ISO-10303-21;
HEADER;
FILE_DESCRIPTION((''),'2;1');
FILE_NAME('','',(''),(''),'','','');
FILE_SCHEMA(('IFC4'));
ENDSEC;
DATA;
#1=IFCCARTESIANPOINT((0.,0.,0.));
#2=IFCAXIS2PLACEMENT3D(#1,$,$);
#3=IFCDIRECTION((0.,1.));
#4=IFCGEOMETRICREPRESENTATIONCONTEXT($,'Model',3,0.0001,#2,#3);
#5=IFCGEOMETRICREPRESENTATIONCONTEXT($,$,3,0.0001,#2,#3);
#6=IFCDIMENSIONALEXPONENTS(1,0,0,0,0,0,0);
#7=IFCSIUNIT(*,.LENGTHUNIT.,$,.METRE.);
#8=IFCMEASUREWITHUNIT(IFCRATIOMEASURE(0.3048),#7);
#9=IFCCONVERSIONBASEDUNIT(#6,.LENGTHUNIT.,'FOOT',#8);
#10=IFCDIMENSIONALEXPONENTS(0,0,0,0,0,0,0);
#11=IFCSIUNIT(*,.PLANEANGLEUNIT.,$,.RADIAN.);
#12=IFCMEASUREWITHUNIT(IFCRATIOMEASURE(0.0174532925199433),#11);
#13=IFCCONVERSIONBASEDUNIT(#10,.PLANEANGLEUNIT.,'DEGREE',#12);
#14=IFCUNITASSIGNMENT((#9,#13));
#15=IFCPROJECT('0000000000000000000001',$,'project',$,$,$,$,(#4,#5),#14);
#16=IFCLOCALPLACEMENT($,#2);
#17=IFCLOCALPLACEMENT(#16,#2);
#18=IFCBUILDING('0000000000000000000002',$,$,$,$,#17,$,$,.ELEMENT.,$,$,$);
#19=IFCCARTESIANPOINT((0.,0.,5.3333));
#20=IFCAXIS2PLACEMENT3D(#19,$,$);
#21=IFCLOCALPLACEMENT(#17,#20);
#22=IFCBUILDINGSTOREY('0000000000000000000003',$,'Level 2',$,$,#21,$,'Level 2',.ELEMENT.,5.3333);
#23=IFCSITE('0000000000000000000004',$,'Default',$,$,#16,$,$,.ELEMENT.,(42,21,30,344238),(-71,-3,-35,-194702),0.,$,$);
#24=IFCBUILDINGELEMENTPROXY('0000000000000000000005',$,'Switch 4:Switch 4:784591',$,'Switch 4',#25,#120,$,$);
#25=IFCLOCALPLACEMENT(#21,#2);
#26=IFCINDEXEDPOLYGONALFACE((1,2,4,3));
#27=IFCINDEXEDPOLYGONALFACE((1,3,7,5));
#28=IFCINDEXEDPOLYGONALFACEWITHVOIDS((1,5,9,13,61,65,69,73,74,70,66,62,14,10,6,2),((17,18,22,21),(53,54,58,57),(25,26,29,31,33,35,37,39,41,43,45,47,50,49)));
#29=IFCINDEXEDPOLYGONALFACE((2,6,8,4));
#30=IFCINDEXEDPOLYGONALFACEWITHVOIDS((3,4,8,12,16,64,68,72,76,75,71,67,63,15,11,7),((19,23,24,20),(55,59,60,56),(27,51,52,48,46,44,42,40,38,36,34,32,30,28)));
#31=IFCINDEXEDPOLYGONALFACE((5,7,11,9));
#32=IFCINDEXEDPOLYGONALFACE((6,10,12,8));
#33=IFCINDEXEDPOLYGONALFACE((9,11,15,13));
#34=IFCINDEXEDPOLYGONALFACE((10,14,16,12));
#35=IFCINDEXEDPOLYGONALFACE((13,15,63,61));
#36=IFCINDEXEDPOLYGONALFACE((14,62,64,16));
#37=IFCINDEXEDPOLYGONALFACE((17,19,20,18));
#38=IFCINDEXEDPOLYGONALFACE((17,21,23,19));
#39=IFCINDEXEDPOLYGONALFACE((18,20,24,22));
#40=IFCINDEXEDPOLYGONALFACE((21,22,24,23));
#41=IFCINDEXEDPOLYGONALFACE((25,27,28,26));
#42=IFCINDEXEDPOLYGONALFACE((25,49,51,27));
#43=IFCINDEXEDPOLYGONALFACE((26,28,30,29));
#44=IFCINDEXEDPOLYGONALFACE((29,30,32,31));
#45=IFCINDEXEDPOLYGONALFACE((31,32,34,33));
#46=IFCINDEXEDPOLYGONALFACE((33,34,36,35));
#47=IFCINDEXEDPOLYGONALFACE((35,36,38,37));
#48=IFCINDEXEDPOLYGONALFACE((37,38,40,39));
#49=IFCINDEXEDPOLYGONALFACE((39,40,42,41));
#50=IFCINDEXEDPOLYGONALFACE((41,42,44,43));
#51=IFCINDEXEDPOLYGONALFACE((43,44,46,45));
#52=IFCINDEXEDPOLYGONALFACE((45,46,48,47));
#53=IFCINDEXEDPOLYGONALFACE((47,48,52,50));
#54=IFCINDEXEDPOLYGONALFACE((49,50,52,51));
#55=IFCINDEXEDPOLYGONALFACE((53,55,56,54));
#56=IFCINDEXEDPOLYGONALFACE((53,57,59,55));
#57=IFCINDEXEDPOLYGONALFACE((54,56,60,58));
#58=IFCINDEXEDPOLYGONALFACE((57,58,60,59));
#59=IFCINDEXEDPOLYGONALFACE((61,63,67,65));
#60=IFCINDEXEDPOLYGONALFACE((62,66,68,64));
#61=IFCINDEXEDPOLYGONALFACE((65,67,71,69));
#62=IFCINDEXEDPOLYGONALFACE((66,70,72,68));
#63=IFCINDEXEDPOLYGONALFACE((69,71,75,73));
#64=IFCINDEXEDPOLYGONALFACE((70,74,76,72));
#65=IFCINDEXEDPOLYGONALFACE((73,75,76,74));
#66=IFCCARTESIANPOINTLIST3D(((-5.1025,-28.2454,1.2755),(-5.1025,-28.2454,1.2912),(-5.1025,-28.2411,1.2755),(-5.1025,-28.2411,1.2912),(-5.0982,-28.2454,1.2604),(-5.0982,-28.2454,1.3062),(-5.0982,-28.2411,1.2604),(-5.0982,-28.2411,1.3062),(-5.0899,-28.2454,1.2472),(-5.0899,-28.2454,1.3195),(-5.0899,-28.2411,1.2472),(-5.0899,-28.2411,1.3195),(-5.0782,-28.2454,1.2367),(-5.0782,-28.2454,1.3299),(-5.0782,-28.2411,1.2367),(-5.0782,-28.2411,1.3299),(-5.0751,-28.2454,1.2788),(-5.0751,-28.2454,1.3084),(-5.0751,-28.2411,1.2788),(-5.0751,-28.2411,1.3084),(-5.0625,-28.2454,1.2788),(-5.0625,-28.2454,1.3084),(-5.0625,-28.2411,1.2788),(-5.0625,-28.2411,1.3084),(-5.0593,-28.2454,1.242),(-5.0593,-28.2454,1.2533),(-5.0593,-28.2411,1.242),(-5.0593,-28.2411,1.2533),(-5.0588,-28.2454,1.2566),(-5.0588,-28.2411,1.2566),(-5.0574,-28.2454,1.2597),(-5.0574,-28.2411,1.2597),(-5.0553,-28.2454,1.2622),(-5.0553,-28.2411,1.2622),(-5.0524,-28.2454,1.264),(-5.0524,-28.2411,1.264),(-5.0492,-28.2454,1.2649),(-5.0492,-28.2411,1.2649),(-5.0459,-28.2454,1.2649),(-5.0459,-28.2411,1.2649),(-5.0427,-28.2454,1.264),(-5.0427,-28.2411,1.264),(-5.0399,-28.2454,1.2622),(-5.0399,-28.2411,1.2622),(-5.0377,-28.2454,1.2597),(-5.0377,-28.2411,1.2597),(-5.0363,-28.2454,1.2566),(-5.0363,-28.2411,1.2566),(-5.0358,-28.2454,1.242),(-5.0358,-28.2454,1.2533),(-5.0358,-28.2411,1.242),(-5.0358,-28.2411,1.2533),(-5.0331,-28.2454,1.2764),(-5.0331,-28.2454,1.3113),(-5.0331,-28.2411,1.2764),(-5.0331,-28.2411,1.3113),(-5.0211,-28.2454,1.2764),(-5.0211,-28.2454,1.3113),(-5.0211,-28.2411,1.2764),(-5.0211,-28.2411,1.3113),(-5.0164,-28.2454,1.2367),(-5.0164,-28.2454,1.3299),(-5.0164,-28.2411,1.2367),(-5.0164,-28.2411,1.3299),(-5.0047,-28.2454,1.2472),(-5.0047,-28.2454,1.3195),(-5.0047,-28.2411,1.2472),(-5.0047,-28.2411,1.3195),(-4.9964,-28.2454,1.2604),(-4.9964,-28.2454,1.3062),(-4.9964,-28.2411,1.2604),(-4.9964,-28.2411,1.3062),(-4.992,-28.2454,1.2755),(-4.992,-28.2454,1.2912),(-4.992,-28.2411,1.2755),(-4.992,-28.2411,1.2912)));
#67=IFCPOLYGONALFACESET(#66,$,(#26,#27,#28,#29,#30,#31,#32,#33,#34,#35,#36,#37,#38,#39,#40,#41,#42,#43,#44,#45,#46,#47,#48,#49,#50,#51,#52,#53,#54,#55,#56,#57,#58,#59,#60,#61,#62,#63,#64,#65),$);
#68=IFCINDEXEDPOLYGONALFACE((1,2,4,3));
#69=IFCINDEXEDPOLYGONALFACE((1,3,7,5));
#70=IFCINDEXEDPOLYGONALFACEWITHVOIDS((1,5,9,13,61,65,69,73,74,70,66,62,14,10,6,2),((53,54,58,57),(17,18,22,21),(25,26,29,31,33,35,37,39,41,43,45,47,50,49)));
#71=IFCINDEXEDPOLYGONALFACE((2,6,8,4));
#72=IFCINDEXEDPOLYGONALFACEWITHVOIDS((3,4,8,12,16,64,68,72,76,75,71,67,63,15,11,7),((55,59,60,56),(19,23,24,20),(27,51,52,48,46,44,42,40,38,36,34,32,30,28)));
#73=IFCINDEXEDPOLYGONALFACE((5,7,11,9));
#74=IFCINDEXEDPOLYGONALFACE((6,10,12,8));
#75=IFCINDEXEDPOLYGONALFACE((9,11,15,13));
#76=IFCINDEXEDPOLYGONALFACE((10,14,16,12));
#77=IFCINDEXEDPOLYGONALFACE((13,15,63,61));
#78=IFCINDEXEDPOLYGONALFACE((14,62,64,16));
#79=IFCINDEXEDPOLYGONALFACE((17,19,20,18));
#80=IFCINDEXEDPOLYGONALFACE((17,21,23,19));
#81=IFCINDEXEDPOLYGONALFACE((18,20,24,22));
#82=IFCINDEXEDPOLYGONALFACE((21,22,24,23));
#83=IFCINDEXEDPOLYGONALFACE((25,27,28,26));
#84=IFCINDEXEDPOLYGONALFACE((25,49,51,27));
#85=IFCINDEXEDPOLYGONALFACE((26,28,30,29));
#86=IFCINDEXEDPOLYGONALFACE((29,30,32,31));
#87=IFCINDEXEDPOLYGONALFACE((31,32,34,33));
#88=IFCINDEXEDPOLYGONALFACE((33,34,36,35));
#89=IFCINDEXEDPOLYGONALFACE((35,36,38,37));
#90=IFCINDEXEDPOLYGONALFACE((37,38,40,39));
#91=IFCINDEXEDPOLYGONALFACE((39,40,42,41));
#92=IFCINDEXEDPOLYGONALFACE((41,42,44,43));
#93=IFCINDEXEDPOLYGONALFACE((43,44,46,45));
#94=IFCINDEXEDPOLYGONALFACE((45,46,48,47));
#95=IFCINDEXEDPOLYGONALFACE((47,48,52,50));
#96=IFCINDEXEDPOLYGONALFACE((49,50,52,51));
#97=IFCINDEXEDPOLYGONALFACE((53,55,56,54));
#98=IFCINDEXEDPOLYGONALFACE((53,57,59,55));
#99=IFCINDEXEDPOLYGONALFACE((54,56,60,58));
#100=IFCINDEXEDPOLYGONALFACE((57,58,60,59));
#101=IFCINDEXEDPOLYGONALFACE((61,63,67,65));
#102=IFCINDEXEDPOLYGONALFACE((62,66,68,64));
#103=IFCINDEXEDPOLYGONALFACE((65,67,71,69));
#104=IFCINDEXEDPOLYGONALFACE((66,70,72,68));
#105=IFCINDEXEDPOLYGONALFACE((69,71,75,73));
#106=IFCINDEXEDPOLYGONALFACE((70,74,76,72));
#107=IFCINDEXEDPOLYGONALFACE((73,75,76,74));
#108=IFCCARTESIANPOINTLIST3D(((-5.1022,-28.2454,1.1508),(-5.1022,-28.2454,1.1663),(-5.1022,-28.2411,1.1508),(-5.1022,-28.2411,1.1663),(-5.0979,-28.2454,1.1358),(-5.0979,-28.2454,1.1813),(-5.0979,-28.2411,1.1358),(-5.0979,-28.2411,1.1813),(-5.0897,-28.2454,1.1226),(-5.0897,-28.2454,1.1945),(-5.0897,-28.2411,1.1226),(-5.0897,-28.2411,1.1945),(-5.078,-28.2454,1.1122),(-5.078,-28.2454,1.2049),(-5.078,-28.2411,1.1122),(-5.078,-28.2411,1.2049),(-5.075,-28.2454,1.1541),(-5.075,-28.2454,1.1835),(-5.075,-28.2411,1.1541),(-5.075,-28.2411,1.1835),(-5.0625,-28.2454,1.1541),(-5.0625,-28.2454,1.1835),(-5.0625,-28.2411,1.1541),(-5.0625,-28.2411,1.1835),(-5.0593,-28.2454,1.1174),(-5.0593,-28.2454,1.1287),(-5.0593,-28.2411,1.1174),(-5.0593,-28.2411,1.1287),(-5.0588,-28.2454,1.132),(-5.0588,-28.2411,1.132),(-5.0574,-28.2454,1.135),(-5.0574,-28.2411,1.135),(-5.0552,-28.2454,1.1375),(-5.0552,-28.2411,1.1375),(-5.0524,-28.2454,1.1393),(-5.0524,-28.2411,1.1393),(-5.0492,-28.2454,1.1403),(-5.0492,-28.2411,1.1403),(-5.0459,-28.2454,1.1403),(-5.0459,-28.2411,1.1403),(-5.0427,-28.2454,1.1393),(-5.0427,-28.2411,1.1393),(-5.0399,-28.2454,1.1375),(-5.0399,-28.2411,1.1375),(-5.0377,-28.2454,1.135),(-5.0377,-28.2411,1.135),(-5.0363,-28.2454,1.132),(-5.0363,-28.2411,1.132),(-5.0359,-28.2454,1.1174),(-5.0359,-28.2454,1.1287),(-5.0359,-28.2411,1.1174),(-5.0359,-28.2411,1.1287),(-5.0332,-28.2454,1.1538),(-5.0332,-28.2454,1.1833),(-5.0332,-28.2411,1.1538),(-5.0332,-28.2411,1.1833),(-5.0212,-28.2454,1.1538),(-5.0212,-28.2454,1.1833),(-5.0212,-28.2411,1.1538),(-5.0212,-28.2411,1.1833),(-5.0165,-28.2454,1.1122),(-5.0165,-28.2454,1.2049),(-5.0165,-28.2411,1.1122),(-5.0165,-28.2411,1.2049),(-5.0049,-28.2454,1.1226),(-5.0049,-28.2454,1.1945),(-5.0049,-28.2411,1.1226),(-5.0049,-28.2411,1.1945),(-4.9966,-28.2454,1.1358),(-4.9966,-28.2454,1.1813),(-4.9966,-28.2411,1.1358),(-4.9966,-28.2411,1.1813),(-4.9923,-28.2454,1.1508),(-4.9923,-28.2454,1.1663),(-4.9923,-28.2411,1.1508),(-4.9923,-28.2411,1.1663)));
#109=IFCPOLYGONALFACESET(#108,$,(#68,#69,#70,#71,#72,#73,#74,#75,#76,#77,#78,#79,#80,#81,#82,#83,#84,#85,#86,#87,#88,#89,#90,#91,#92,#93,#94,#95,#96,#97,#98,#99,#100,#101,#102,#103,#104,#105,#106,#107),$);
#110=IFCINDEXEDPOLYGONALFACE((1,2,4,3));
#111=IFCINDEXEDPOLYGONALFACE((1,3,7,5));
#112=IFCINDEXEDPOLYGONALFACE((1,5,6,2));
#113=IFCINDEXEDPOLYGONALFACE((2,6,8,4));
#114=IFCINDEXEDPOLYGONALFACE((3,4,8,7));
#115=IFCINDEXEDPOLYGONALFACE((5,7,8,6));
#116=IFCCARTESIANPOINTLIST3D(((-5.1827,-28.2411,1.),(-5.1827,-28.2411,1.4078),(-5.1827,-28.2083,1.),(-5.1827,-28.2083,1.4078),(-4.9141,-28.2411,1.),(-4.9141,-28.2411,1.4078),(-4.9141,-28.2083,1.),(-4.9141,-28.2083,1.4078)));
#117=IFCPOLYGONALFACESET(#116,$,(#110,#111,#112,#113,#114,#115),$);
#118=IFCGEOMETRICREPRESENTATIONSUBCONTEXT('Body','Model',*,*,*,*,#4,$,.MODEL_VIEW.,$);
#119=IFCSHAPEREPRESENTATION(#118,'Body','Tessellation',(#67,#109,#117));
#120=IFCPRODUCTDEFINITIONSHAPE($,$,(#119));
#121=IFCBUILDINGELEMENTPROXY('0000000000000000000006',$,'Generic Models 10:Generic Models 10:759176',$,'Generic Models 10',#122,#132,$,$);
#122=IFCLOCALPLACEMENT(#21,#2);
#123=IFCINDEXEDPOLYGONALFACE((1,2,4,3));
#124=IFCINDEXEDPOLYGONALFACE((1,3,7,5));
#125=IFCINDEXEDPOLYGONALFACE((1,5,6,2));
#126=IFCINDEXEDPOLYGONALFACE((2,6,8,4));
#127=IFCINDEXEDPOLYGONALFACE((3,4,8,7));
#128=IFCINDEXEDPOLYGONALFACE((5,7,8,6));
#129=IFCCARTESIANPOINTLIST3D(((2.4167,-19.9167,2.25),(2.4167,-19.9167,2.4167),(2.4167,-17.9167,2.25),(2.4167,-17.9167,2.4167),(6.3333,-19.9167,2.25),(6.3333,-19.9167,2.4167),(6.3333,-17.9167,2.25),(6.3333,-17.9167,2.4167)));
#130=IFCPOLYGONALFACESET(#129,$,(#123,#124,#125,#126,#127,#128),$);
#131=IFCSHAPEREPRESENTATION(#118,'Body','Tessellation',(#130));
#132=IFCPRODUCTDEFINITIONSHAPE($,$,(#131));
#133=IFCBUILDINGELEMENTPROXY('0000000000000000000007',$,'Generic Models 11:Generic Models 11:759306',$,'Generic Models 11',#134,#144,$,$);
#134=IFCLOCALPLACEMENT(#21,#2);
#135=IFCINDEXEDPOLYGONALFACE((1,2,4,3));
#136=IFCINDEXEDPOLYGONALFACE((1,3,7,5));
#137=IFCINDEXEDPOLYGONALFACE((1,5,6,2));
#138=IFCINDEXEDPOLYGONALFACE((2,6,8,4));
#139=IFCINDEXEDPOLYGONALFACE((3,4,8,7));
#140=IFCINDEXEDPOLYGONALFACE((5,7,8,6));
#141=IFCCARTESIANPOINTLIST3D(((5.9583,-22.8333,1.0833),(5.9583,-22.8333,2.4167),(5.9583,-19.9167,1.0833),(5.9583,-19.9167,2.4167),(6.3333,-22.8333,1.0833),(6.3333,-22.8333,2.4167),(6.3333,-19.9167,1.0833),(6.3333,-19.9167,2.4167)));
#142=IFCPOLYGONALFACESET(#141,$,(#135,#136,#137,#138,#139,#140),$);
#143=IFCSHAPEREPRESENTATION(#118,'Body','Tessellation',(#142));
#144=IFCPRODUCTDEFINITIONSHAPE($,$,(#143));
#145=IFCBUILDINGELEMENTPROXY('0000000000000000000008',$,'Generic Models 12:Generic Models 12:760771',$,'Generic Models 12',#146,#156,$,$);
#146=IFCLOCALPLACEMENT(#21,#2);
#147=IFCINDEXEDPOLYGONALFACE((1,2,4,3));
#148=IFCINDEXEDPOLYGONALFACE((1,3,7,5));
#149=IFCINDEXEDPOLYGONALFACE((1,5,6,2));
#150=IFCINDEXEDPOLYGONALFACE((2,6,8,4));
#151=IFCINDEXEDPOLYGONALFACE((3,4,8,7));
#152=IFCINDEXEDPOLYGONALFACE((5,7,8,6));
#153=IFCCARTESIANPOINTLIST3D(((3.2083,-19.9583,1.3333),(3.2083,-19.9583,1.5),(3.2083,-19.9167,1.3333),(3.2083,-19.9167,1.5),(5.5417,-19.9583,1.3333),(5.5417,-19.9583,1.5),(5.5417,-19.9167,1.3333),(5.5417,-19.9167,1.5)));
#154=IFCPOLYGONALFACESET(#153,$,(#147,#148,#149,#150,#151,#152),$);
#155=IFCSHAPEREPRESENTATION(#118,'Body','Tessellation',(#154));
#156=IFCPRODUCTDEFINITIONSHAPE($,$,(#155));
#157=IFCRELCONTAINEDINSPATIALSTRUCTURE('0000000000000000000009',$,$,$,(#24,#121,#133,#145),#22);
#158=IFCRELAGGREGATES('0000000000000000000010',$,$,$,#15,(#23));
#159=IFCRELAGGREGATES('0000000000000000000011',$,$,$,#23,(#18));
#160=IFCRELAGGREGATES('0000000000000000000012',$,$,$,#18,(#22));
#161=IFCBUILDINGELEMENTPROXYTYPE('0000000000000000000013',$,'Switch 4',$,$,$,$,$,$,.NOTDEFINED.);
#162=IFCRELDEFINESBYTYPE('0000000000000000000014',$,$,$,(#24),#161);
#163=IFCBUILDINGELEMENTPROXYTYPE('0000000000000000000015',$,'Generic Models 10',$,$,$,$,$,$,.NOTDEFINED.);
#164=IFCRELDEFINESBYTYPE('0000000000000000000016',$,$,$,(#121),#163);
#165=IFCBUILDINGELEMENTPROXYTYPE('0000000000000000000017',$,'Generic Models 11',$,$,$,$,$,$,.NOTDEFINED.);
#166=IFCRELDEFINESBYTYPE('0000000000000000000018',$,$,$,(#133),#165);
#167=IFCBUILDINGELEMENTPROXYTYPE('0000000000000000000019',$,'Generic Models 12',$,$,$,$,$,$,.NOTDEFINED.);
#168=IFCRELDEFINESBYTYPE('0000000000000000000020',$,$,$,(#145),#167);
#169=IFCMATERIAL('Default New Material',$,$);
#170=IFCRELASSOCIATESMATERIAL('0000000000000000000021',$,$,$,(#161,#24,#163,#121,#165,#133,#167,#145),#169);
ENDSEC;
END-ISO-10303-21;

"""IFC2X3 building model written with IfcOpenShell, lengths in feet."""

from ifc_helpers import new_model, entity, si_unit, converted_unit, direction, frame, frame_2d, origin, origin_2d_with_axis, place, context, subcontext, project, spatial, polyline, circle_curve, parameter, trimmed, segment, composite_curve, rectangle, outline, extrude, source, transform, mapped, material, type_object, type_shapes, element, save


model = new_model("IFC2X3")

# Units and contexts
model_context = context("Model", 3, precision=0.0001, world=origin(), true_north=direction((0.0, 1.0)))
context_of_model = context(None, 3, precision=0.0001, world=origin(), true_north=direction((0.0, 1.0)))
body_context = subcontext(model_context, "Body", "Model", "MODEL_VIEW")
ifc_project = project(units=[converted_unit("LENGTHUNIT", "FOOT", entity("IfcRatioMeasure", 0.3048), si_unit("LENGTHUNIT", "METRE"), dimensions=[1, 0, 0, 0, 0, 0, 0]), converted_unit("PLANEANGLEUNIT", "DEGREE", entity("IfcRatioMeasure", 0.0174532925199433), si_unit("PLANEANGLEUNIT", "RADIAN"), dimensions=[0, 0, 0, 0, 0, 0, 0])], contexts=[model_context, context_of_model])

# Site, building, storey
site_placement = place(None, origin())
site = spatial("IfcSite", under=ifc_project, at=site_placement, Name="Default", CompositionType="ELEMENT", RefLatitude=(42, 21, 30, 344238), RefLongitude=(-71, -3, -35, -194702), RefElevation=0.0)
building_placement = place(site_placement, origin())
building = spatial("IfcBuilding", under=site, at=building_placement, CompositionType="ELEMENT")
storey_placement = place(building_placement, frame((0.0, 0.0, 5.3333)))
storey = spatial("IfcBuildingStorey", under=building, at=storey_placement, Name="Level 2", LongName="Level 2", CompositionType="ELEMENT", Elevation=5.3333)

# Shared definitions
ifc_material_1 = material(Name="Default New Material")

# Building element proxies
building_element_proxy_type_1 = type_object("IfcBuildingElementProxyType", Name="Switch 4", PredefinedType="NOTDEFINED", material=ifc_material_1)
shared_shape_1 = source(origin(), body_context, "Body", "SweptSolid", [
    extrude(outline(composite_curve([segment(polyline([(-0.0309, -0.0466), (0.0309, -0.0466)]), True, "CONTINUOUS"), segment(trimmed(circle_curve(frame_2d((-0.0003, 0.0), x_axis=(-1.0, 0.0)), 0.0561), [parameter(123.794741)], [parameter(236.205259)], True, "PARAMETER"), True, "CONTINUOUS"), segment(polyline([(0.0309, 0.0466), (-0.0309, 0.0466)]), True, "CONTINUOUS"), segment(trimmed(circle_curve(frame_2d((0.0003, 0.0), x_axis=(1.0, 0.0)), 0.0561), [parameter(123.794741)], [parameter(236.205259)], True, "PARAMETER"), True, "CONTINUOUS")], self_intersect=False), holes=[polyline([(0.0142, 0.0279), (0.0262, 0.0279), (0.0262, -0.0069), (0.0142, -0.0069), (0.0142, 0.0279)]), polyline([(-0.0153, 0.025), (-0.0153, -0.0045), (-0.0278, -0.0045), (-0.0278, 0.025), (-0.0153, 0.025)]), composite_curve([segment(polyline([(-0.012, -0.0413), (-0.012, -0.03)]), True, "CONTINUOUS"), segment(trimmed(circle_curve(frame_2d((-0.0003, -0.03), x_axis=(-1.0, 0.0)), 0.0117), [parameter(180.0)], [parameter(0.0)], True, "PARAMETER"), False, "CONTINUOUS"), segment(polyline([(0.0115, -0.03), (0.0115, -0.0413)]), True, "CONTINUOUS"), segment(polyline([(0.0115, -0.0413), (-0.012, -0.0413)]), True, "CONTINUOUS")], self_intersect=False)]), frame((-0.0011, 0.0328, 0.2833), z_axis=(0.0, 1.0, 0.0), x_axis=(-1.0, 0.0, 0.0)), (0.0, 0.0, 1.0), 0.0042),
    extrude(outline(composite_curve([segment(polyline([(-0.0308, -0.0464), (0.0308, -0.0464)]), True, "CONTINUOUS"), segment(trimmed(circle_curve(frame_2d((-0.0003, 0.0), x_axis=(-1.0, 0.0)), 0.0558), [parameter(123.794741)], [parameter(236.205259)], True, "PARAMETER"), True, "CONTINUOUS"), segment(polyline([(0.0308, 0.0464), (-0.0308, 0.0464)]), True, "CONTINUOUS"), segment(trimmed(circle_curve(frame_2d((0.0003, 0.0), x_axis=(1.0, 0.0)), 0.0558), [parameter(123.794741)], [parameter(236.205259)], True, "PARAMETER"), True, "CONTINUOUS")], self_intersect=False), holes=[polyline([(0.0141, 0.0247), (0.026, 0.0247), (0.026, -0.0047), (0.0141, -0.0047), (0.0141, 0.0247)]), polyline([(-0.0152, 0.0249), (-0.0152, -0.0045), (-0.0277, -0.0045), (-0.0277, 0.0249), (-0.0152, 0.0249)]), composite_curve([segment(polyline([(-0.012, -0.0411), (-0.012, -0.0299)]), True, "CONTINUOUS"), segment(trimmed(circle_curve(frame_2d((-0.0003, -0.0299), x_axis=(-1.0, 0.0)), 0.0117), [parameter(180.0)], [parameter(0.0)], True, "PARAMETER"), False, "CONTINUOUS"), segment(polyline([(0.0114, -0.0299), (0.0114, -0.0411)]), True, "CONTINUOUS"), segment(polyline([(0.0114, -0.0411), (-0.012, -0.0411)]), True, "CONTINUOUS")], self_intersect=False)]), frame((-0.0011, 0.0328, 0.1586), z_axis=(0.0, 1.0, 0.0), x_axis=(-1.0, 0.0, 0.0)), (0.0, 0.0, 1.0), 0.0042),
    extrude(rectangle(XDim=0.0328, YDim=0.2687, at=origin_2d_with_axis()), frame((0.0, 0.0164, 0.0), z_axis=(0.0, 0.0, 1.0), x_axis=(0.0, -1.0, 0.0)), (0.0, 0.0, 1.0), 0.4078),
])
type_shapes(building_element_proxy_type_1, [shared_shape_1])
proxy_1_placement = place(storey_placement, frame((-5.0484, -28.2083, 1.0), z_axis=(0.0, 0.0, 1.0), x_axis=(-1.0, 0.0, 0.0)))
element("IfcBuildingElementProxy", 1, at=proxy_1_placement, inside=storey, type_object=building_element_proxy_type_1, material=ifc_material_1, Name="Switch 4:Switch 4:784591", ObjectType="Switch 4", context=body_context, shape_type="MappedRepresentation", body=[
    mapped(shared_shape_1, transform((0.0, 0.0, 0.0), scale=1.0)),
])
building_element_proxy_type_2 = type_object("IfcBuildingElementProxyType", Name="Generic Models 10", PredefinedType="NOTDEFINED", material=ifc_material_1)
shared_shape_2 = source(origin(), body_context, "Body", "SweptSolid", [
    extrude(rectangle(XDim=3.9167, YDim=2.0, at=frame_2d((0.0, 0.0), x_axis=(1.0, 0.0))), frame((1.9583, 1.0, 0.0), z_axis=(0.0, 0.0, 1.0), x_axis=(-1.0, 0.0, 0.0)), (0.0, 0.0, 1.0), 0.1667),
])
type_shapes(building_element_proxy_type_2, [shared_shape_2])
proxy_2_placement = place(storey_placement, frame((2.4167, -19.9167, 2.25)))
element("IfcBuildingElementProxy", 2, at=proxy_2_placement, inside=storey, type_object=building_element_proxy_type_2, material=ifc_material_1, Name="Generic Models 10:Generic Models 10:759176", ObjectType="Generic Models 10", context=body_context, shape_type="MappedRepresentation", body=[
    mapped(shared_shape_2, transform((0.0, 0.0, 0.0), scale=1.0)),
])
building_element_proxy_type_3 = type_object("IfcBuildingElementProxyType", Name="Generic Models 11", PredefinedType="NOTDEFINED", material=ifc_material_1)
shared_shape_3 = source(origin(), body_context, "Body", "SweptSolid", [
    extrude(rectangle(XDim=0.375, YDim=2.9167, at=frame_2d((0.0, 0.0), x_axis=(1.0, 0.0))), frame((0.1875, 1.4583, 0.0), z_axis=(0.0, 0.0, 1.0), x_axis=(-1.0, 0.0, 0.0)), (0.0, 0.0, 1.0), 1.3333),
])
type_shapes(building_element_proxy_type_3, [shared_shape_3])
proxy_3_placement = place(storey_placement, frame((5.9583, -22.8333, 1.0833)))
element("IfcBuildingElementProxy", 3, at=proxy_3_placement, inside=storey, type_object=building_element_proxy_type_3, material=ifc_material_1, Name="Generic Models 11:Generic Models 11:759306", ObjectType="Generic Models 11", context=body_context, shape_type="MappedRepresentation", body=[
    mapped(shared_shape_3, transform((0.0, 0.0, 0.0), scale=1.0)),
])
building_element_proxy_type_4 = type_object("IfcBuildingElementProxyType", Name="Generic Models 12", PredefinedType="NOTDEFINED", material=ifc_material_1)
shared_shape_4 = source(origin(), body_context, "Body", "SweptSolid", [
    extrude(rectangle(XDim=0.0417, YDim=2.3333, at=frame_2d((0.0, 0.0), x_axis=(1.0, 0.0))), frame((1.1667, 0.0208, 0.0), z_axis=(0.0, 0.0, 1.0), x_axis=(0.0, 1.0, 0.0)), (0.0, 0.0, 1.0), 0.1667),
])
type_shapes(building_element_proxy_type_4, [shared_shape_4])
proxy_4_placement = place(storey_placement, frame((3.2083, -19.9583, 1.3333)))
element("IfcBuildingElementProxy", 4, at=proxy_4_placement, inside=storey, type_object=building_element_proxy_type_4, material=ifc_material_1, Name="Generic Models 12:Generic Models 12:760771", ObjectType="Generic Models 12", context=body_context, shape_type="MappedRepresentation", body=[
    mapped(shared_shape_4, transform((0.0, 0.0, 0.0), scale=1.0)),
])

save(model, "model.ifc")
